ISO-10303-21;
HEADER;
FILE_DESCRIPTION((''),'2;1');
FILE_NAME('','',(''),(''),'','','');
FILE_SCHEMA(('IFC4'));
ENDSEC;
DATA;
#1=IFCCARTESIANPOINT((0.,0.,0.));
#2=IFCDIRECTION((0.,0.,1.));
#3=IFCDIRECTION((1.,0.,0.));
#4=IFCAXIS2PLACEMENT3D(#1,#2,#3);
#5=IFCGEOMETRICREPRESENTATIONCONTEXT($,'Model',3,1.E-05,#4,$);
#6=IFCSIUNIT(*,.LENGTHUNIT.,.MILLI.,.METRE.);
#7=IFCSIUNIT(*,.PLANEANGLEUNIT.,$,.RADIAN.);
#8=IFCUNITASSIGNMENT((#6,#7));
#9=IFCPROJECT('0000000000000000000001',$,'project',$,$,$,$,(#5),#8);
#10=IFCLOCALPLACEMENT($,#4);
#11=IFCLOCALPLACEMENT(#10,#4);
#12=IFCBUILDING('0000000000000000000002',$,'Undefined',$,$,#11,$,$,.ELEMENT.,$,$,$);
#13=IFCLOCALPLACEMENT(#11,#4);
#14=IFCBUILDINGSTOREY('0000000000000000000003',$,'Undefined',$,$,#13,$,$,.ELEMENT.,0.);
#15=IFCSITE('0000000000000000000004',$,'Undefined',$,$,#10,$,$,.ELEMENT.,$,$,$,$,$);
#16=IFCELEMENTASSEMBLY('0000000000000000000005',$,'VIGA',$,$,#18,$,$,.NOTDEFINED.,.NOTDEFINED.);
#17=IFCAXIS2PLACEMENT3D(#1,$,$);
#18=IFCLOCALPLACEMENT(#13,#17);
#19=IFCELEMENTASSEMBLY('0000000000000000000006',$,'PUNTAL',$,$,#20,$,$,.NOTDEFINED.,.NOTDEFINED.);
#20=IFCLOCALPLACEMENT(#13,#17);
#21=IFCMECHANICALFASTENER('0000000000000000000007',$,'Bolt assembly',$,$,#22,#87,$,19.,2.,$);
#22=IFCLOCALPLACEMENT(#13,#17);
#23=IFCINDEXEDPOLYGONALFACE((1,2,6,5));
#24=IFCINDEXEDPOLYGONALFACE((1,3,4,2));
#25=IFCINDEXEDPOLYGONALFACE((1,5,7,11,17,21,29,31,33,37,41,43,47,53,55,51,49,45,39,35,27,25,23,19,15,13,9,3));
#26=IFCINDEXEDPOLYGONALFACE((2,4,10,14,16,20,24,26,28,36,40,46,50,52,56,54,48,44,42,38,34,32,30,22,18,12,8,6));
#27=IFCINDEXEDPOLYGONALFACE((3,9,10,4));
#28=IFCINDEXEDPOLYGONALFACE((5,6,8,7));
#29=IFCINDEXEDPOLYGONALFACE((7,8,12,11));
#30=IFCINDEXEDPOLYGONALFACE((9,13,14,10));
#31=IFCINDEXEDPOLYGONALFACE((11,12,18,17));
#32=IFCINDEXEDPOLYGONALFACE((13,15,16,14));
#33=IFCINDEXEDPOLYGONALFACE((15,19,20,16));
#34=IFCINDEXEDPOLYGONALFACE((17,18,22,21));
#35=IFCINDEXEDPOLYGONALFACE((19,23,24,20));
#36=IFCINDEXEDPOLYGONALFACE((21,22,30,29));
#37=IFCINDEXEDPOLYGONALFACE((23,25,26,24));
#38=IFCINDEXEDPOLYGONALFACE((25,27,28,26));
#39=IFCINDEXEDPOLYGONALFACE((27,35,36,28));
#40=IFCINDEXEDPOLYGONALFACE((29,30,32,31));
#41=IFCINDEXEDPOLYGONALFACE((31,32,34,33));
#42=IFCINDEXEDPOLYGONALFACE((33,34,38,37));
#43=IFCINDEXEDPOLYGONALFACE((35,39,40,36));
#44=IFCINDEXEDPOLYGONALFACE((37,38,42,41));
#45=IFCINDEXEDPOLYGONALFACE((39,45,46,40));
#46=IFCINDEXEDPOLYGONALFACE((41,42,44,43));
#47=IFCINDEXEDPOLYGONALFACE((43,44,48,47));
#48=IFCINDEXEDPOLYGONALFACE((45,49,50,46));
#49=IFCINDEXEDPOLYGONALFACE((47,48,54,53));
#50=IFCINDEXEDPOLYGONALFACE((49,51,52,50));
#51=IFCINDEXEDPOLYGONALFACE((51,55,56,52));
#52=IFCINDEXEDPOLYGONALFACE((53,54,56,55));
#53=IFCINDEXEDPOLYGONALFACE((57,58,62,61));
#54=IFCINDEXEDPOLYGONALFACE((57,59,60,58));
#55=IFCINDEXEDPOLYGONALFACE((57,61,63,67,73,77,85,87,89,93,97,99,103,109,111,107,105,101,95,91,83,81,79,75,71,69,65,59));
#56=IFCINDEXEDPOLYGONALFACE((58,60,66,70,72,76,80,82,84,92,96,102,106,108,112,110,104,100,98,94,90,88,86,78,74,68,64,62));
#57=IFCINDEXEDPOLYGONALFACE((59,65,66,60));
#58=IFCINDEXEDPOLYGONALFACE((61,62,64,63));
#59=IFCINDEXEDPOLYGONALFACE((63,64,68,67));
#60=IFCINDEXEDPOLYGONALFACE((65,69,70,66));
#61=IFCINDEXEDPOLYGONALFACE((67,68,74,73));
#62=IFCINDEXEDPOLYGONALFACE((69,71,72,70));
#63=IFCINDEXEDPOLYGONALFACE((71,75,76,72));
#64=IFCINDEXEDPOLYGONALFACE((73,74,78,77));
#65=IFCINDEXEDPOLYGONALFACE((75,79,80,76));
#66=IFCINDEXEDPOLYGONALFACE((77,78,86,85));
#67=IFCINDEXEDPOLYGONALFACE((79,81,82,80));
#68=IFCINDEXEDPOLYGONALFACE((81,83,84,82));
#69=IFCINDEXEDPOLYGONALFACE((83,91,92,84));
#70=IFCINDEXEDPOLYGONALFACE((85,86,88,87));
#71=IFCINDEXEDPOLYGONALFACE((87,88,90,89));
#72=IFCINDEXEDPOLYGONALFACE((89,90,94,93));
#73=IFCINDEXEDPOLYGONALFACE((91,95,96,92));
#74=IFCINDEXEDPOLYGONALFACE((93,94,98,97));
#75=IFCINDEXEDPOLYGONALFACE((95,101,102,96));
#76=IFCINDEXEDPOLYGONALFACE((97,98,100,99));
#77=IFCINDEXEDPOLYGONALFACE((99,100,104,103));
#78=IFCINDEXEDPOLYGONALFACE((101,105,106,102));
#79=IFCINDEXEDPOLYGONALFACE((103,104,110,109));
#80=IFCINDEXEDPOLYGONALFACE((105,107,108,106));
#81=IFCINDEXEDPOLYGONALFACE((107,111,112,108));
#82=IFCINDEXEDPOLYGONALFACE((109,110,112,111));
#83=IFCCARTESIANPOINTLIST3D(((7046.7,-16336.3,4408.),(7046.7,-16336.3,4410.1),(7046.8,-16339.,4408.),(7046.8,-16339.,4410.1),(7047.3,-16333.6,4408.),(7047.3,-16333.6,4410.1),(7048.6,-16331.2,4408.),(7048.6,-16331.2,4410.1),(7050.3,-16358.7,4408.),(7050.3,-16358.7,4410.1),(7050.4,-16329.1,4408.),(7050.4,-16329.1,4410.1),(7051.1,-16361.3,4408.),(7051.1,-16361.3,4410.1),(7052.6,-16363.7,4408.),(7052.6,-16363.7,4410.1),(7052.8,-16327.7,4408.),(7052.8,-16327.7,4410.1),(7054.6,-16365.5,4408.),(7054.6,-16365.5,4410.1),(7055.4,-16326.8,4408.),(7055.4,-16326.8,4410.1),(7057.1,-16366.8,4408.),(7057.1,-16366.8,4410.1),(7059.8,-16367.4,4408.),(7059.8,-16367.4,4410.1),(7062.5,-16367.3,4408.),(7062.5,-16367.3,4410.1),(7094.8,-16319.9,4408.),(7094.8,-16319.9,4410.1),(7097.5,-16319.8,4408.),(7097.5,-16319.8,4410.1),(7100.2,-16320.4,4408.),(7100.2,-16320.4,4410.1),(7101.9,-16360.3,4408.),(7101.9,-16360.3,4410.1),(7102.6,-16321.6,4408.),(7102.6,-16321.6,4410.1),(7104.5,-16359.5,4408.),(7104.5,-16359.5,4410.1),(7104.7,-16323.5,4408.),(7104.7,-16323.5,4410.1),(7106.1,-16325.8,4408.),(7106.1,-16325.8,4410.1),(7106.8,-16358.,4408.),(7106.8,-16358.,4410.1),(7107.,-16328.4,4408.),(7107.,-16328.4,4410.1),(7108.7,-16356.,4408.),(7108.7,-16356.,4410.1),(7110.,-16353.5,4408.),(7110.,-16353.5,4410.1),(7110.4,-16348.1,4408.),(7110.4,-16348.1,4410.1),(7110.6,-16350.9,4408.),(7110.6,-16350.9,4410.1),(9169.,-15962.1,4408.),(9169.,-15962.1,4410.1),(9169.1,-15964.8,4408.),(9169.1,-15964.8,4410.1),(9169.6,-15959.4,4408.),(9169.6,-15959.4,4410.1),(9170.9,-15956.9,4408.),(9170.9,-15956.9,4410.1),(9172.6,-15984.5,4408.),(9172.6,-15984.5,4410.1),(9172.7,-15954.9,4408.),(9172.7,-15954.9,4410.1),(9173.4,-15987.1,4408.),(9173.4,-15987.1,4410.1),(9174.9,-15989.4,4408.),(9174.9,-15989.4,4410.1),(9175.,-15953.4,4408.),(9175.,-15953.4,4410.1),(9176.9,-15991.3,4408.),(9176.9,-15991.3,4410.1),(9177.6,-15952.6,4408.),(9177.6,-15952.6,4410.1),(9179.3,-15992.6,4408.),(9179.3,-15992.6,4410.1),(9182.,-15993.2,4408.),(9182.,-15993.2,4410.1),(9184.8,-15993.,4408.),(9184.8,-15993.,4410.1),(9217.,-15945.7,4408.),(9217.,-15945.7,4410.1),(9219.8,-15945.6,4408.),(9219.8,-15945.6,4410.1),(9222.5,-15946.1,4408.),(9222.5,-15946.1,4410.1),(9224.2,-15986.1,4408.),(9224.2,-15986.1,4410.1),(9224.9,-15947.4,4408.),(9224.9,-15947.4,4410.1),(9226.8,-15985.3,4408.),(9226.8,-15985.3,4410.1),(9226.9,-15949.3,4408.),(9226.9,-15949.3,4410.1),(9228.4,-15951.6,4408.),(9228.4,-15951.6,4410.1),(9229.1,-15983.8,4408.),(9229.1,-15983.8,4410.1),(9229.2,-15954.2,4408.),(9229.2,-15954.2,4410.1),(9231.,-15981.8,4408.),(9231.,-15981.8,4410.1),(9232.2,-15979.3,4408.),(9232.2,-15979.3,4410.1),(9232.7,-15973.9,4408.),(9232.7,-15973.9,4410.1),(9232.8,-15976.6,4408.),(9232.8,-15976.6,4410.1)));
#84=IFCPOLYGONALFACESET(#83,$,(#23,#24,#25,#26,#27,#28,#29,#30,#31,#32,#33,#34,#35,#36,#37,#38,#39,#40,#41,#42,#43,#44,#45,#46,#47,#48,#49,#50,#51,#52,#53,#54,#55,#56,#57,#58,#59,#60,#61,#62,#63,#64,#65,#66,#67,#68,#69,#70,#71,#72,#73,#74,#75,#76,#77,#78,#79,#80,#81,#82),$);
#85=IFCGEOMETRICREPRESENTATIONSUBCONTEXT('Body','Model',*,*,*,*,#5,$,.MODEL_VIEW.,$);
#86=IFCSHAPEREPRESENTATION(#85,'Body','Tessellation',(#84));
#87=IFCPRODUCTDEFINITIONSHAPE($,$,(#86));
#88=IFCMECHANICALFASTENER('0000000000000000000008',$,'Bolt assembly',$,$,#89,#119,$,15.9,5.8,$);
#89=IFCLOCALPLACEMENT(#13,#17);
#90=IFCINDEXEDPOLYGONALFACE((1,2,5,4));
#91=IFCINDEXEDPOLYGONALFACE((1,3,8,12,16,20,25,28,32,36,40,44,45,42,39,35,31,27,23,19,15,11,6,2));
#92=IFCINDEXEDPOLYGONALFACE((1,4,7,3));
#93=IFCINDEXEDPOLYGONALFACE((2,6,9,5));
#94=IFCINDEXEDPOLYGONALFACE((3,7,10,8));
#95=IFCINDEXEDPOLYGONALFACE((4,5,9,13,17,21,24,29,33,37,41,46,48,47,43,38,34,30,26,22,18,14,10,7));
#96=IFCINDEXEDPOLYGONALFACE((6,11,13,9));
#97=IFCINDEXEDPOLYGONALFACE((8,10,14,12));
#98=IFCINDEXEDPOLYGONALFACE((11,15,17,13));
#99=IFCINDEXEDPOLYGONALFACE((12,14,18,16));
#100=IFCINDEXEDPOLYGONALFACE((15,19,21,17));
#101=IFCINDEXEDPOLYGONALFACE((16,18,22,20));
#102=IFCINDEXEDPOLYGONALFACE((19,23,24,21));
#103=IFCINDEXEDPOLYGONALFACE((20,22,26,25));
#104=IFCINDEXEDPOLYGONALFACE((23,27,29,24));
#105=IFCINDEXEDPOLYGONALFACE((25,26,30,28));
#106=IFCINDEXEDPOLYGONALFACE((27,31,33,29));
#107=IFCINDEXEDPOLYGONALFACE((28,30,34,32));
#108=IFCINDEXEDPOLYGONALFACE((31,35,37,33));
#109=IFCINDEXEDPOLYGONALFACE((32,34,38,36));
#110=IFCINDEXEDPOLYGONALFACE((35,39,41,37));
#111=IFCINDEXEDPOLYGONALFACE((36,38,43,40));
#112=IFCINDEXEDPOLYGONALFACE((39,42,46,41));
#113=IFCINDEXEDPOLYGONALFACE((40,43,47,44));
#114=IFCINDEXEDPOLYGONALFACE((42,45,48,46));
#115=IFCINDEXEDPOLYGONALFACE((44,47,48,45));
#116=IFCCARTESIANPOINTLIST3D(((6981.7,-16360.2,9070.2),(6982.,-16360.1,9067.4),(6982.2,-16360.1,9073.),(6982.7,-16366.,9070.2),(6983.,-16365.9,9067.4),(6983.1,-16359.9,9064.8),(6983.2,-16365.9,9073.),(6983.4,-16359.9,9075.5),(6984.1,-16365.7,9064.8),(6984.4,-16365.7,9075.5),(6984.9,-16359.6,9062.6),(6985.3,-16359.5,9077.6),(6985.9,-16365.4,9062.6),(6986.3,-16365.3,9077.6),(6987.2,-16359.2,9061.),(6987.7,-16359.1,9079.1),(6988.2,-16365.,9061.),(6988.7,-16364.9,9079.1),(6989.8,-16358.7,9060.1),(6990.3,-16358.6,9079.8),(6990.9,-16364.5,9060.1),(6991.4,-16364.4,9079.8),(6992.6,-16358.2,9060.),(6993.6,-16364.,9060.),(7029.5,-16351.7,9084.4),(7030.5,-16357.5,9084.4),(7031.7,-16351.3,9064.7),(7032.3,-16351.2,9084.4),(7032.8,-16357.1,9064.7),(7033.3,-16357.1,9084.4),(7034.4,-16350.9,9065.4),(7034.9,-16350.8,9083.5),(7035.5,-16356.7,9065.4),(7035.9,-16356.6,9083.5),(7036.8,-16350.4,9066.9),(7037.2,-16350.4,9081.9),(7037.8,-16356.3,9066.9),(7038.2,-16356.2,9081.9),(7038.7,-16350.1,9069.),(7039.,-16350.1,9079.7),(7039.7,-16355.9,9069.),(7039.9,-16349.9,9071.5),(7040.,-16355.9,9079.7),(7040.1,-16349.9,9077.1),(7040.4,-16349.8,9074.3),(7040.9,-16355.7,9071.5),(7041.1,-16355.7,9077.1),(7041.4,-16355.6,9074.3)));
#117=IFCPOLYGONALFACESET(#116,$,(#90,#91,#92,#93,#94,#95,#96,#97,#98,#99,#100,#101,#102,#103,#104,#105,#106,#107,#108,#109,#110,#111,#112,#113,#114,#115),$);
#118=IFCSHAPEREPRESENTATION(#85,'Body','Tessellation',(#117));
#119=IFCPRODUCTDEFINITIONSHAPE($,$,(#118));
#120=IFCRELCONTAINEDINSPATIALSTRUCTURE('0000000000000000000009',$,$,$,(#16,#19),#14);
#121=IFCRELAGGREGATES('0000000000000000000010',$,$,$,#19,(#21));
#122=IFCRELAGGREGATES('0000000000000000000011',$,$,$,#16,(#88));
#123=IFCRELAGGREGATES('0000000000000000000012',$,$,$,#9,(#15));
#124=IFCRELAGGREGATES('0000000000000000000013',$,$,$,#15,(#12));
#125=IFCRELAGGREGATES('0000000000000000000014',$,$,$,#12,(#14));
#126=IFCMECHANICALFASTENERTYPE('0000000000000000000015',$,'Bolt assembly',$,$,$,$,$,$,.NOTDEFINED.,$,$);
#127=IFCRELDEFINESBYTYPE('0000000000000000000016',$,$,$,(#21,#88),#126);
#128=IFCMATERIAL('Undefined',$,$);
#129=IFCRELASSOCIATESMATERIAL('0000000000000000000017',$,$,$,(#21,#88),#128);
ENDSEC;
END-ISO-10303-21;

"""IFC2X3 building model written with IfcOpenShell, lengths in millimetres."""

from ifc_helpers import new_model, si_unit, frame, frame_2d, origin_with_axes, place, context, subcontext, project, spatial, polyline, circle_curve, parameter, trimmed, segment, composite_curve, outline, extrude, source, transform, mapped, material, type_object, element, aggregate, save


model = new_model("IFC2X3")

# Units and contexts
model_context = context("Model", 3, precision=1e-05, world=origin_with_axes())
body_context = subcontext(model_context, "Body", "Model", "MODEL_VIEW")
ifc_project = project(units=[si_unit("LENGTHUNIT", "METRE", prefix="MILLI"), si_unit("PLANEANGLEUNIT", "RADIAN")], contexts=[model_context])

# Site, building, storey
site_placement = place(None, origin_with_axes())
site = spatial("IfcSite", under=ifc_project, at=site_placement, Name="Undefined", CompositionType="ELEMENT")
building_placement = place(site_placement, origin_with_axes())
building = spatial("IfcBuilding", under=site, at=building_placement, Name="Undefined", CompositionType="ELEMENT")
storey_placement = place(building_placement, origin_with_axes())
storey = spatial("IfcBuildingStorey", under=building, at=storey_placement, Name="Undefined", CompositionType="ELEMENT", Elevation=0.0)

# Element assembly
assembly_1_placement = place(storey_placement, origin_with_axes())
assembly_1 = element("IfcElementAssembly", 1, at=assembly_1_placement, inside=storey, Name="VIGA", AssemblyPlace="NOTDEFINED", PredefinedType="NOTDEFINED")

# Element assembly, mechanical fastener
ifc_material_1 = material(Name="Undefined")
mechanical_fastener_type = type_object("IfcMechanicalFastenerType", Name="Bolt assembly")
assembly_2_placement = place(storey_placement, origin_with_axes())
assembly_2 = element("IfcElementAssembly", 2, at=assembly_2_placement, inside=storey, Name="PUNTAL", AssemblyPlace="NOTDEFINED", PredefinedType="NOTDEFINED")
shared_shape_1 = source(origin_with_axes(), body_context, "Body", "SweptSolid", [
    extrude(outline(composite_curve([segment(polyline([(-20.0, 20.5), (20.0, 20.5)]), True, "CONTINUOUS"), segment(trimmed(circle_curve(frame_2d((20.0, 10.0), x_axis=(0.0, 1.0)), 10.5), [parameter(0.0)], [parameter(4.712389)], False, "PARAMETER"), True, "CONTINUOUS"), segment(polyline([(30.5, 10.0), (30.5, -10.0)]), True, "CONTINUOUS"), segment(trimmed(circle_curve(frame_2d((20.0, -10.0), x_axis=(1.0, 0.0)), 10.5), [parameter(0.0)], [parameter(4.712389)], False, "PARAMETER"), True, "CONTINUOUS"), segment(polyline([(20.0, -20.5), (-20.0, -20.5)]), True, "CONTINUOUS"), segment(trimmed(circle_curve(frame_2d((-20.0, -10.0), x_axis=(0.0, -1.0)), 10.5), [parameter(0.0)], [parameter(4.712389)], False, "PARAMETER"), True, "CONTINUOUS"), segment(polyline([(-30.5, -10.0), (-30.5, 10.0)]), True, "CONTINUOUS"), segment(trimmed(circle_curve(frame_2d((-20.0, 10.0), x_axis=(-1.0, 0.0)), 10.5), [parameter(0.0)], [parameter(4.712389)], False, "PARAMETER"), True, "DISCONTINUOUS")], self_intersect=False)), frame((0.0, -2.0, 0.0), z_axis=(0.0, 1.0, 0.0), x_axis=(1.0, 0.0, 0.0)), (0.0, 0.0, 1.0), 2.1),
])
mechanical_fastener_1_placement = place(assembly_2_placement, frame((7078.6, -16343.6, 4410.0), z_axis=(0.173648, -0.984808, 0.0), x_axis=(0.984808, 0.173648, 0.000002)))
mechanical_fastener_1 = element("IfcMechanicalFastener", 3, at=mechanical_fastener_1_placement, type_object=mechanical_fastener_type, material=ifc_material_1, Name="Bolt assembly", NominalDiameter=19.0, NominalLength=2.0, context=body_context, shape_type="MappedRepresentation", body=[
    mapped(shared_shape_1, transform((0.0, 0.0, 0.0))),
    mapped(shared_shape_1, transform((2155.0, 0.0, 0.0))),
])
aggregate(assembly_2, [mechanical_fastener_1])

# Mechanical fastener
shared_shape_2 = source(origin_with_axes(), body_context, "Body", "SweptSolid", [
    extrude(outline(composite_curve([segment(polyline([(-20.0, 9.9), (20.0, 9.9)]), True, "CONTINUOUS"), segment(trimmed(circle_curve(frame_2d((20.0, 0.0), x_axis=(0.0, 1.0)), 9.9), [parameter(0.0)], [parameter(3.141593)], False, "PARAMETER"), True, "CONTINUOUS"), segment(polyline([(20.0, -9.9), (-20.0, -9.9)]), True, "CONTINUOUS"), segment(trimmed(circle_curve(frame_2d((-20.0, 0.0), x_axis=(0.0, -1.0)), 9.9), [parameter(0.0)], [parameter(3.141593)], False, "PARAMETER"), True, "DISCONTINUOUS")], self_intersect=False)), frame((0.0, -2.9, 0.0), z_axis=(0.0, 1.0, 0.0), x_axis=(1.0, 0.0, 0.0)), (0.0, 0.0, 1.0), 5.9),
])
mechanical_fastener_2_placement = place(assembly_1_placement, frame((7011.6, -16357.9, 9072.2), z_axis=(0.114223, 0.020141, -0.993251), x_axis=(-0.978161, -0.172476, -0.115985)))
mechanical_fastener_2 = element("IfcMechanicalFastener", 4, at=mechanical_fastener_2_placement, type_object=mechanical_fastener_type, material=ifc_material_1, Name="Bolt assembly", NominalDiameter=15.9, NominalLength=5.8, context=body_context, shape_type="MappedRepresentation", body=[
    mapped(shared_shape_2, transform((0.0, 0.0, 0.0))),
])
aggregate(assembly_1, [mechanical_fastener_2])

save(model, "model.ifc")
